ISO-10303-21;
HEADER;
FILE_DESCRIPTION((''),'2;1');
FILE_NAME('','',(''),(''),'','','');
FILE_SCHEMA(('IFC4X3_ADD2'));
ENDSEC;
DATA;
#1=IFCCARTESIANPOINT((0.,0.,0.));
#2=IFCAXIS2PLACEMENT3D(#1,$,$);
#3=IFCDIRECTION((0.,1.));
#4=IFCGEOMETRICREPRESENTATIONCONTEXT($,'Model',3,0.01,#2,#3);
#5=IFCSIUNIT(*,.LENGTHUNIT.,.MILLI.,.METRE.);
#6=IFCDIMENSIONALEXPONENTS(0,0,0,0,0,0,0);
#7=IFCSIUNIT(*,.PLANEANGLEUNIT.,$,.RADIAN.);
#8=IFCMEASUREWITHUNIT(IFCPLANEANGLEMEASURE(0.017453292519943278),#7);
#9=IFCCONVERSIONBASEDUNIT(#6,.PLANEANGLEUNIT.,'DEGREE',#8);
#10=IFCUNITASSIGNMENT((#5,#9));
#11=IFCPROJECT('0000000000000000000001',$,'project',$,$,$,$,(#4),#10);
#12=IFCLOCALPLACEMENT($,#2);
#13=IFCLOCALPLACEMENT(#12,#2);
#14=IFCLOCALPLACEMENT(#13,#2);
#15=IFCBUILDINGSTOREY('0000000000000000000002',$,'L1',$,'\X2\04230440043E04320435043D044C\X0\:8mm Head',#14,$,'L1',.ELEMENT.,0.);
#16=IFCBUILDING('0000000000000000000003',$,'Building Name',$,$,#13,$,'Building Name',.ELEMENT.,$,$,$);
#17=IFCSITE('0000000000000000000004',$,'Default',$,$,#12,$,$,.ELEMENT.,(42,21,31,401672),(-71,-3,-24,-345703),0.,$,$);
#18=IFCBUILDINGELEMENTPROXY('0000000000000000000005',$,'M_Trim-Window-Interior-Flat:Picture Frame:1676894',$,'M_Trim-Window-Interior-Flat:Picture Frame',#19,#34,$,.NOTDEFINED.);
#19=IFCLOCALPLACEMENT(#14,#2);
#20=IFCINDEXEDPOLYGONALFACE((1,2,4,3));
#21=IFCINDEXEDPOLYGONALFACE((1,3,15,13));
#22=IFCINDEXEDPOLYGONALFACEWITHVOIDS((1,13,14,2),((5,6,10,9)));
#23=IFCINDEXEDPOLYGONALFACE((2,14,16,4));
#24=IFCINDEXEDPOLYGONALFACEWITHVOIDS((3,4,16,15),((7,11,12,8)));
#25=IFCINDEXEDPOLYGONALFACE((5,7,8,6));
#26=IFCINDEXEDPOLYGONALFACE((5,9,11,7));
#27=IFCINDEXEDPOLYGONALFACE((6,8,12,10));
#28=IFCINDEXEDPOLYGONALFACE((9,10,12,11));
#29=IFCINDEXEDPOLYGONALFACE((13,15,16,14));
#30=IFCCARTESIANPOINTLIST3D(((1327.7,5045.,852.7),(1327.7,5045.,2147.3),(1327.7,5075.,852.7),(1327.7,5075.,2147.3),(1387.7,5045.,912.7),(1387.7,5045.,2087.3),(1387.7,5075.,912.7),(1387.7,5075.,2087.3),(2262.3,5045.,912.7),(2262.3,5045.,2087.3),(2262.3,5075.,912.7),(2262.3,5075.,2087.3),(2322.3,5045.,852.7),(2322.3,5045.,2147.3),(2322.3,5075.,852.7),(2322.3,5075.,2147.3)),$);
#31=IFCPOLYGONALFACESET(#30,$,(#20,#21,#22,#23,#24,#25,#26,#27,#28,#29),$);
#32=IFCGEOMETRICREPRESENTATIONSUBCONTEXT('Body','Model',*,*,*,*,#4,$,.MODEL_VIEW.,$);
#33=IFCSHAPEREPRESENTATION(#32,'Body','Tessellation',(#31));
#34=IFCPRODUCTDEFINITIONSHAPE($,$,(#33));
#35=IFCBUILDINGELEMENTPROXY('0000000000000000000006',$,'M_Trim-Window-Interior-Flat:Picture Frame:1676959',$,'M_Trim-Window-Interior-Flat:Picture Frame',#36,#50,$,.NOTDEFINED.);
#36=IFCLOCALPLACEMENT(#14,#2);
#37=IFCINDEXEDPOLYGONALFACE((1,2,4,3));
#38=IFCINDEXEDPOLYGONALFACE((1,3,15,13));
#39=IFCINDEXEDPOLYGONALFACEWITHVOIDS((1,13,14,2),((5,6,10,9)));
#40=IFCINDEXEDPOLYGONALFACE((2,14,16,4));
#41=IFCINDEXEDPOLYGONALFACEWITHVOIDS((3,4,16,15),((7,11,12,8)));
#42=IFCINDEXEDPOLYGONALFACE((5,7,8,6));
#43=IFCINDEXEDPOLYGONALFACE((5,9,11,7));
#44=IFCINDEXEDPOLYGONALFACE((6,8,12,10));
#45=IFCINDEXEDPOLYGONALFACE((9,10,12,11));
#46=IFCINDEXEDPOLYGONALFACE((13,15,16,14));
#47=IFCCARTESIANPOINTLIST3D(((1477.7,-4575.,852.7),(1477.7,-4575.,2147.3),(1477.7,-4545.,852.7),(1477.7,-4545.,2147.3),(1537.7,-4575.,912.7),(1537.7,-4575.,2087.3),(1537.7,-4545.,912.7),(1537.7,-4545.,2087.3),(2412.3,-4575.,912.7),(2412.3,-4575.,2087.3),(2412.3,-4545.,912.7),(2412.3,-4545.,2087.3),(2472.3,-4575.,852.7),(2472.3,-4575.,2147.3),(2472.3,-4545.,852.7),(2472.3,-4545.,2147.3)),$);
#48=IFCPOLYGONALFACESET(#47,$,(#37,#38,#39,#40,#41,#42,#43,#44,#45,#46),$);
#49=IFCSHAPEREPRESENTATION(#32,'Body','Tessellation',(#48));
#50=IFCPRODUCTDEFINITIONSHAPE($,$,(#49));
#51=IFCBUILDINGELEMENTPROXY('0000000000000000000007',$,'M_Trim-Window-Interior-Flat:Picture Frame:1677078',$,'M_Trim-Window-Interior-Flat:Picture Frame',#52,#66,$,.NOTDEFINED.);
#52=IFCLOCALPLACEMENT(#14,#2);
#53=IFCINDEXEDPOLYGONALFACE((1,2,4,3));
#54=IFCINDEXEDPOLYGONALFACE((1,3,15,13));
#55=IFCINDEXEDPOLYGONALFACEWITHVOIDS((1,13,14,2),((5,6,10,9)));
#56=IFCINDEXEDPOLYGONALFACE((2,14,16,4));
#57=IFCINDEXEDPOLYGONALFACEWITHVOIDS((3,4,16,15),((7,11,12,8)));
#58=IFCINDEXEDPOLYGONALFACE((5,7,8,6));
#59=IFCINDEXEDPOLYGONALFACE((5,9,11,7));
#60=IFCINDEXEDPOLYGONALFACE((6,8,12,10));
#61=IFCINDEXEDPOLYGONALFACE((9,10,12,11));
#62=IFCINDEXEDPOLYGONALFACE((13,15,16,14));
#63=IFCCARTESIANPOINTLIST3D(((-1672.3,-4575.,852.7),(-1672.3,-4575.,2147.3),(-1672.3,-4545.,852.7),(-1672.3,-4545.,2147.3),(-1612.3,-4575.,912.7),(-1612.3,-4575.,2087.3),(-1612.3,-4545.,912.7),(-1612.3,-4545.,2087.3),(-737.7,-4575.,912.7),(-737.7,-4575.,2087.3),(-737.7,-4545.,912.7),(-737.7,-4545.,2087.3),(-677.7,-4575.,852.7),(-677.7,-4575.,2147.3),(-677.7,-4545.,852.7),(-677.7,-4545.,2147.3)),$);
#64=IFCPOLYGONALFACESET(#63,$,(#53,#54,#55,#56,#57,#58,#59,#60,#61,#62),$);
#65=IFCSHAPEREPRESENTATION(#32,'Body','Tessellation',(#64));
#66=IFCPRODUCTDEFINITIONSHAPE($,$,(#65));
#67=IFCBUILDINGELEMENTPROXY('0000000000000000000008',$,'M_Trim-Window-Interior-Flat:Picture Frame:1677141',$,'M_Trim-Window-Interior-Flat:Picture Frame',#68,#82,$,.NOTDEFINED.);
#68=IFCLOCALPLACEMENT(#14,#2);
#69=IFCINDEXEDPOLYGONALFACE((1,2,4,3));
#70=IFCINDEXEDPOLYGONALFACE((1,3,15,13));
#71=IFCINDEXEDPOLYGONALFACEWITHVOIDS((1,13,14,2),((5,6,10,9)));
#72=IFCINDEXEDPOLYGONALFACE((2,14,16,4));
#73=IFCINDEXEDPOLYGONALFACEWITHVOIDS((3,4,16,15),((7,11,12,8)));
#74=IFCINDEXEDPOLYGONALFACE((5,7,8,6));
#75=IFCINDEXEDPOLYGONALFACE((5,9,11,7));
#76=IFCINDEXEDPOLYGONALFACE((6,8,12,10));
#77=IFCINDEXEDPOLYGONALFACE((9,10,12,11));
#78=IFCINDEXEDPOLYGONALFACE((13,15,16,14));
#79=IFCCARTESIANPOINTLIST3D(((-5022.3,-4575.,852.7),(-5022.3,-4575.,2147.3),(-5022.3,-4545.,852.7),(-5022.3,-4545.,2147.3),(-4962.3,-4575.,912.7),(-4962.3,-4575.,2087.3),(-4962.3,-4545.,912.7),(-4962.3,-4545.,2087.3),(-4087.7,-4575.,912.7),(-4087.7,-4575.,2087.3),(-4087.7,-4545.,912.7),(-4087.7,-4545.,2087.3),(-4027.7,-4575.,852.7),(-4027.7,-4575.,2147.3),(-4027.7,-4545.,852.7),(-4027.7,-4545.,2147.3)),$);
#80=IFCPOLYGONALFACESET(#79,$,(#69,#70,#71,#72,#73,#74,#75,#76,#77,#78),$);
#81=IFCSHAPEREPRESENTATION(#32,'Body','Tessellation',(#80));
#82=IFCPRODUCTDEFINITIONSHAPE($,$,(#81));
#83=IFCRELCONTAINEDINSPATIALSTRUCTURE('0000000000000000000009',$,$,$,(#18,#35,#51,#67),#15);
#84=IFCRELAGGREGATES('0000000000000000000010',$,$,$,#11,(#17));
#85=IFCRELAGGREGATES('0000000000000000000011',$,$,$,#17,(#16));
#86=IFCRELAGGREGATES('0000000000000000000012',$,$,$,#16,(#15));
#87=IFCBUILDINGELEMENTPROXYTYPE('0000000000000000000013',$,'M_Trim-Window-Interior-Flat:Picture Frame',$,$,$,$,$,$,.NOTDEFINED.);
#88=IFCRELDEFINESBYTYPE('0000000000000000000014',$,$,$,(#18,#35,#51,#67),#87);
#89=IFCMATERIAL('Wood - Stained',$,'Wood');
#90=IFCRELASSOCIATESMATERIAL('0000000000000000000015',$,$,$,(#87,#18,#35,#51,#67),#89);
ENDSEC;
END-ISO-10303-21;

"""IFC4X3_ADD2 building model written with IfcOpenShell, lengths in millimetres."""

from ifc_helpers import new_model, entity, si_unit, converted_unit, direction, frame, origin, place, context, subcontext, project, spatial, polyline, outline, extrude, source, transform, mapped, material, type_object, type_shapes, element, save


model = new_model("IFC4X3_ADD2")

# Units and contexts
model_context = context("Model", 3, precision=0.01, world=origin(), true_north=direction((0.0, 1.0)))
body_context = subcontext(model_context, "Body", "Model", "MODEL_VIEW")
ifc_project = project(units=[si_unit("LENGTHUNIT", "METRE", prefix="MILLI"), converted_unit("PLANEANGLEUNIT", "DEGREE", entity("IfcPlaneAngleMeasure", 0.017453292519943278), si_unit("PLANEANGLEUNIT", "RADIAN"), dimensions=[0, 0, 0, 0, 0, 0, 0])], contexts=[model_context])

# Site, building, storey
site_placement = place(None, origin())
site = spatial("IfcSite", under=ifc_project, at=site_placement, Name="Default", CompositionType="ELEMENT", RefLatitude=(42, 21, 31, 401672), RefLongitude=(-71, -3, -24, -345703), RefElevation=0.0)
building_placement = place(site_placement, origin())
building = spatial("IfcBuilding", under=site, at=building_placement, Name="Building Name", LongName="Building Name", CompositionType="ELEMENT")
storey_placement = place(building_placement, origin())
storey = spatial("IfcBuildingStorey", under=building, at=storey_placement, Name="L1", ObjectType="Уровень:8mm Head", LongName="L1", CompositionType="ELEMENT", Elevation=0.0)

# Building element proxies
ifc_material_1 = material(Name="Wood - Stained", Category="Wood")
building_element_proxy_type_1 = type_object("IfcBuildingElementProxyType", Name="M_Trim-Window-Interior-Flat:Picture Frame", PredefinedType="NOTDEFINED", material=ifc_material_1)
shared_shape_1 = source(origin(), body_context, "Body", "SweptSolid", [
    extrude(outline(polyline([(-497.3, -647.3), (497.3, -647.3), (497.3, 647.3), (-497.3, 647.3), (-497.3, -647.3)]), holes=[polyline([(-437.3, -587.3), (-437.3, 587.3), (437.3, 587.3), (437.3, -587.3), (-437.3, -587.3)])]), frame((0.0, -600.0, 0.0), z_axis=(0.0, 0.0, 1.0), x_axis=(-1.0, 0.0, 0.0)), (0.0, 0.0, 1.0), 30.0),
])
type_shapes(building_element_proxy_type_1, [shared_shape_1])
for number, where, z_axis, x_axis, name in (
    (1, (1825.0, 5075.0, 2100.0), (0.0, -1.0, 0.0), (1.0, 0.0, 0.0), "M_Trim-Window-Interior-Flat:Picture Frame:1676894"),
    (2, (1975.0, -4575.0, 2100.0), (0.0, 1.0, 0.0), (-1.0, 0.0, 0.0), "M_Trim-Window-Interior-Flat:Picture Frame:1676959"),
    (3, (-1175.0, -4575.0, 2100.0), (0.0, 1.0, 0.0), (-1.0, 0.0, 0.0), "M_Trim-Window-Interior-Flat:Picture Frame:1677078"),
    (4, (-4525.0, -4575.0, 2100.0), (0.0, 1.0, 0.0), (-1.0, 0.0, 0.0), "M_Trim-Window-Interior-Flat:Picture Frame:1677141"),
):
    element("IfcBuildingElementProxy", number, at=place(storey_placement, frame(where, z_axis=z_axis, x_axis=x_axis)), inside=storey, type_object=building_element_proxy_type_1, material=ifc_material_1, Name=name, ObjectType="M_Trim-Window-Interior-Flat:Picture Frame", PredefinedType="NOTDEFINED", context=body_context, shape_type="MappedRepresentation", body=[
        mapped(shared_shape_1, transform((0.0, 0.0, 0.0), scale=1.0)),
    ])

save(model, "model.ifc")
